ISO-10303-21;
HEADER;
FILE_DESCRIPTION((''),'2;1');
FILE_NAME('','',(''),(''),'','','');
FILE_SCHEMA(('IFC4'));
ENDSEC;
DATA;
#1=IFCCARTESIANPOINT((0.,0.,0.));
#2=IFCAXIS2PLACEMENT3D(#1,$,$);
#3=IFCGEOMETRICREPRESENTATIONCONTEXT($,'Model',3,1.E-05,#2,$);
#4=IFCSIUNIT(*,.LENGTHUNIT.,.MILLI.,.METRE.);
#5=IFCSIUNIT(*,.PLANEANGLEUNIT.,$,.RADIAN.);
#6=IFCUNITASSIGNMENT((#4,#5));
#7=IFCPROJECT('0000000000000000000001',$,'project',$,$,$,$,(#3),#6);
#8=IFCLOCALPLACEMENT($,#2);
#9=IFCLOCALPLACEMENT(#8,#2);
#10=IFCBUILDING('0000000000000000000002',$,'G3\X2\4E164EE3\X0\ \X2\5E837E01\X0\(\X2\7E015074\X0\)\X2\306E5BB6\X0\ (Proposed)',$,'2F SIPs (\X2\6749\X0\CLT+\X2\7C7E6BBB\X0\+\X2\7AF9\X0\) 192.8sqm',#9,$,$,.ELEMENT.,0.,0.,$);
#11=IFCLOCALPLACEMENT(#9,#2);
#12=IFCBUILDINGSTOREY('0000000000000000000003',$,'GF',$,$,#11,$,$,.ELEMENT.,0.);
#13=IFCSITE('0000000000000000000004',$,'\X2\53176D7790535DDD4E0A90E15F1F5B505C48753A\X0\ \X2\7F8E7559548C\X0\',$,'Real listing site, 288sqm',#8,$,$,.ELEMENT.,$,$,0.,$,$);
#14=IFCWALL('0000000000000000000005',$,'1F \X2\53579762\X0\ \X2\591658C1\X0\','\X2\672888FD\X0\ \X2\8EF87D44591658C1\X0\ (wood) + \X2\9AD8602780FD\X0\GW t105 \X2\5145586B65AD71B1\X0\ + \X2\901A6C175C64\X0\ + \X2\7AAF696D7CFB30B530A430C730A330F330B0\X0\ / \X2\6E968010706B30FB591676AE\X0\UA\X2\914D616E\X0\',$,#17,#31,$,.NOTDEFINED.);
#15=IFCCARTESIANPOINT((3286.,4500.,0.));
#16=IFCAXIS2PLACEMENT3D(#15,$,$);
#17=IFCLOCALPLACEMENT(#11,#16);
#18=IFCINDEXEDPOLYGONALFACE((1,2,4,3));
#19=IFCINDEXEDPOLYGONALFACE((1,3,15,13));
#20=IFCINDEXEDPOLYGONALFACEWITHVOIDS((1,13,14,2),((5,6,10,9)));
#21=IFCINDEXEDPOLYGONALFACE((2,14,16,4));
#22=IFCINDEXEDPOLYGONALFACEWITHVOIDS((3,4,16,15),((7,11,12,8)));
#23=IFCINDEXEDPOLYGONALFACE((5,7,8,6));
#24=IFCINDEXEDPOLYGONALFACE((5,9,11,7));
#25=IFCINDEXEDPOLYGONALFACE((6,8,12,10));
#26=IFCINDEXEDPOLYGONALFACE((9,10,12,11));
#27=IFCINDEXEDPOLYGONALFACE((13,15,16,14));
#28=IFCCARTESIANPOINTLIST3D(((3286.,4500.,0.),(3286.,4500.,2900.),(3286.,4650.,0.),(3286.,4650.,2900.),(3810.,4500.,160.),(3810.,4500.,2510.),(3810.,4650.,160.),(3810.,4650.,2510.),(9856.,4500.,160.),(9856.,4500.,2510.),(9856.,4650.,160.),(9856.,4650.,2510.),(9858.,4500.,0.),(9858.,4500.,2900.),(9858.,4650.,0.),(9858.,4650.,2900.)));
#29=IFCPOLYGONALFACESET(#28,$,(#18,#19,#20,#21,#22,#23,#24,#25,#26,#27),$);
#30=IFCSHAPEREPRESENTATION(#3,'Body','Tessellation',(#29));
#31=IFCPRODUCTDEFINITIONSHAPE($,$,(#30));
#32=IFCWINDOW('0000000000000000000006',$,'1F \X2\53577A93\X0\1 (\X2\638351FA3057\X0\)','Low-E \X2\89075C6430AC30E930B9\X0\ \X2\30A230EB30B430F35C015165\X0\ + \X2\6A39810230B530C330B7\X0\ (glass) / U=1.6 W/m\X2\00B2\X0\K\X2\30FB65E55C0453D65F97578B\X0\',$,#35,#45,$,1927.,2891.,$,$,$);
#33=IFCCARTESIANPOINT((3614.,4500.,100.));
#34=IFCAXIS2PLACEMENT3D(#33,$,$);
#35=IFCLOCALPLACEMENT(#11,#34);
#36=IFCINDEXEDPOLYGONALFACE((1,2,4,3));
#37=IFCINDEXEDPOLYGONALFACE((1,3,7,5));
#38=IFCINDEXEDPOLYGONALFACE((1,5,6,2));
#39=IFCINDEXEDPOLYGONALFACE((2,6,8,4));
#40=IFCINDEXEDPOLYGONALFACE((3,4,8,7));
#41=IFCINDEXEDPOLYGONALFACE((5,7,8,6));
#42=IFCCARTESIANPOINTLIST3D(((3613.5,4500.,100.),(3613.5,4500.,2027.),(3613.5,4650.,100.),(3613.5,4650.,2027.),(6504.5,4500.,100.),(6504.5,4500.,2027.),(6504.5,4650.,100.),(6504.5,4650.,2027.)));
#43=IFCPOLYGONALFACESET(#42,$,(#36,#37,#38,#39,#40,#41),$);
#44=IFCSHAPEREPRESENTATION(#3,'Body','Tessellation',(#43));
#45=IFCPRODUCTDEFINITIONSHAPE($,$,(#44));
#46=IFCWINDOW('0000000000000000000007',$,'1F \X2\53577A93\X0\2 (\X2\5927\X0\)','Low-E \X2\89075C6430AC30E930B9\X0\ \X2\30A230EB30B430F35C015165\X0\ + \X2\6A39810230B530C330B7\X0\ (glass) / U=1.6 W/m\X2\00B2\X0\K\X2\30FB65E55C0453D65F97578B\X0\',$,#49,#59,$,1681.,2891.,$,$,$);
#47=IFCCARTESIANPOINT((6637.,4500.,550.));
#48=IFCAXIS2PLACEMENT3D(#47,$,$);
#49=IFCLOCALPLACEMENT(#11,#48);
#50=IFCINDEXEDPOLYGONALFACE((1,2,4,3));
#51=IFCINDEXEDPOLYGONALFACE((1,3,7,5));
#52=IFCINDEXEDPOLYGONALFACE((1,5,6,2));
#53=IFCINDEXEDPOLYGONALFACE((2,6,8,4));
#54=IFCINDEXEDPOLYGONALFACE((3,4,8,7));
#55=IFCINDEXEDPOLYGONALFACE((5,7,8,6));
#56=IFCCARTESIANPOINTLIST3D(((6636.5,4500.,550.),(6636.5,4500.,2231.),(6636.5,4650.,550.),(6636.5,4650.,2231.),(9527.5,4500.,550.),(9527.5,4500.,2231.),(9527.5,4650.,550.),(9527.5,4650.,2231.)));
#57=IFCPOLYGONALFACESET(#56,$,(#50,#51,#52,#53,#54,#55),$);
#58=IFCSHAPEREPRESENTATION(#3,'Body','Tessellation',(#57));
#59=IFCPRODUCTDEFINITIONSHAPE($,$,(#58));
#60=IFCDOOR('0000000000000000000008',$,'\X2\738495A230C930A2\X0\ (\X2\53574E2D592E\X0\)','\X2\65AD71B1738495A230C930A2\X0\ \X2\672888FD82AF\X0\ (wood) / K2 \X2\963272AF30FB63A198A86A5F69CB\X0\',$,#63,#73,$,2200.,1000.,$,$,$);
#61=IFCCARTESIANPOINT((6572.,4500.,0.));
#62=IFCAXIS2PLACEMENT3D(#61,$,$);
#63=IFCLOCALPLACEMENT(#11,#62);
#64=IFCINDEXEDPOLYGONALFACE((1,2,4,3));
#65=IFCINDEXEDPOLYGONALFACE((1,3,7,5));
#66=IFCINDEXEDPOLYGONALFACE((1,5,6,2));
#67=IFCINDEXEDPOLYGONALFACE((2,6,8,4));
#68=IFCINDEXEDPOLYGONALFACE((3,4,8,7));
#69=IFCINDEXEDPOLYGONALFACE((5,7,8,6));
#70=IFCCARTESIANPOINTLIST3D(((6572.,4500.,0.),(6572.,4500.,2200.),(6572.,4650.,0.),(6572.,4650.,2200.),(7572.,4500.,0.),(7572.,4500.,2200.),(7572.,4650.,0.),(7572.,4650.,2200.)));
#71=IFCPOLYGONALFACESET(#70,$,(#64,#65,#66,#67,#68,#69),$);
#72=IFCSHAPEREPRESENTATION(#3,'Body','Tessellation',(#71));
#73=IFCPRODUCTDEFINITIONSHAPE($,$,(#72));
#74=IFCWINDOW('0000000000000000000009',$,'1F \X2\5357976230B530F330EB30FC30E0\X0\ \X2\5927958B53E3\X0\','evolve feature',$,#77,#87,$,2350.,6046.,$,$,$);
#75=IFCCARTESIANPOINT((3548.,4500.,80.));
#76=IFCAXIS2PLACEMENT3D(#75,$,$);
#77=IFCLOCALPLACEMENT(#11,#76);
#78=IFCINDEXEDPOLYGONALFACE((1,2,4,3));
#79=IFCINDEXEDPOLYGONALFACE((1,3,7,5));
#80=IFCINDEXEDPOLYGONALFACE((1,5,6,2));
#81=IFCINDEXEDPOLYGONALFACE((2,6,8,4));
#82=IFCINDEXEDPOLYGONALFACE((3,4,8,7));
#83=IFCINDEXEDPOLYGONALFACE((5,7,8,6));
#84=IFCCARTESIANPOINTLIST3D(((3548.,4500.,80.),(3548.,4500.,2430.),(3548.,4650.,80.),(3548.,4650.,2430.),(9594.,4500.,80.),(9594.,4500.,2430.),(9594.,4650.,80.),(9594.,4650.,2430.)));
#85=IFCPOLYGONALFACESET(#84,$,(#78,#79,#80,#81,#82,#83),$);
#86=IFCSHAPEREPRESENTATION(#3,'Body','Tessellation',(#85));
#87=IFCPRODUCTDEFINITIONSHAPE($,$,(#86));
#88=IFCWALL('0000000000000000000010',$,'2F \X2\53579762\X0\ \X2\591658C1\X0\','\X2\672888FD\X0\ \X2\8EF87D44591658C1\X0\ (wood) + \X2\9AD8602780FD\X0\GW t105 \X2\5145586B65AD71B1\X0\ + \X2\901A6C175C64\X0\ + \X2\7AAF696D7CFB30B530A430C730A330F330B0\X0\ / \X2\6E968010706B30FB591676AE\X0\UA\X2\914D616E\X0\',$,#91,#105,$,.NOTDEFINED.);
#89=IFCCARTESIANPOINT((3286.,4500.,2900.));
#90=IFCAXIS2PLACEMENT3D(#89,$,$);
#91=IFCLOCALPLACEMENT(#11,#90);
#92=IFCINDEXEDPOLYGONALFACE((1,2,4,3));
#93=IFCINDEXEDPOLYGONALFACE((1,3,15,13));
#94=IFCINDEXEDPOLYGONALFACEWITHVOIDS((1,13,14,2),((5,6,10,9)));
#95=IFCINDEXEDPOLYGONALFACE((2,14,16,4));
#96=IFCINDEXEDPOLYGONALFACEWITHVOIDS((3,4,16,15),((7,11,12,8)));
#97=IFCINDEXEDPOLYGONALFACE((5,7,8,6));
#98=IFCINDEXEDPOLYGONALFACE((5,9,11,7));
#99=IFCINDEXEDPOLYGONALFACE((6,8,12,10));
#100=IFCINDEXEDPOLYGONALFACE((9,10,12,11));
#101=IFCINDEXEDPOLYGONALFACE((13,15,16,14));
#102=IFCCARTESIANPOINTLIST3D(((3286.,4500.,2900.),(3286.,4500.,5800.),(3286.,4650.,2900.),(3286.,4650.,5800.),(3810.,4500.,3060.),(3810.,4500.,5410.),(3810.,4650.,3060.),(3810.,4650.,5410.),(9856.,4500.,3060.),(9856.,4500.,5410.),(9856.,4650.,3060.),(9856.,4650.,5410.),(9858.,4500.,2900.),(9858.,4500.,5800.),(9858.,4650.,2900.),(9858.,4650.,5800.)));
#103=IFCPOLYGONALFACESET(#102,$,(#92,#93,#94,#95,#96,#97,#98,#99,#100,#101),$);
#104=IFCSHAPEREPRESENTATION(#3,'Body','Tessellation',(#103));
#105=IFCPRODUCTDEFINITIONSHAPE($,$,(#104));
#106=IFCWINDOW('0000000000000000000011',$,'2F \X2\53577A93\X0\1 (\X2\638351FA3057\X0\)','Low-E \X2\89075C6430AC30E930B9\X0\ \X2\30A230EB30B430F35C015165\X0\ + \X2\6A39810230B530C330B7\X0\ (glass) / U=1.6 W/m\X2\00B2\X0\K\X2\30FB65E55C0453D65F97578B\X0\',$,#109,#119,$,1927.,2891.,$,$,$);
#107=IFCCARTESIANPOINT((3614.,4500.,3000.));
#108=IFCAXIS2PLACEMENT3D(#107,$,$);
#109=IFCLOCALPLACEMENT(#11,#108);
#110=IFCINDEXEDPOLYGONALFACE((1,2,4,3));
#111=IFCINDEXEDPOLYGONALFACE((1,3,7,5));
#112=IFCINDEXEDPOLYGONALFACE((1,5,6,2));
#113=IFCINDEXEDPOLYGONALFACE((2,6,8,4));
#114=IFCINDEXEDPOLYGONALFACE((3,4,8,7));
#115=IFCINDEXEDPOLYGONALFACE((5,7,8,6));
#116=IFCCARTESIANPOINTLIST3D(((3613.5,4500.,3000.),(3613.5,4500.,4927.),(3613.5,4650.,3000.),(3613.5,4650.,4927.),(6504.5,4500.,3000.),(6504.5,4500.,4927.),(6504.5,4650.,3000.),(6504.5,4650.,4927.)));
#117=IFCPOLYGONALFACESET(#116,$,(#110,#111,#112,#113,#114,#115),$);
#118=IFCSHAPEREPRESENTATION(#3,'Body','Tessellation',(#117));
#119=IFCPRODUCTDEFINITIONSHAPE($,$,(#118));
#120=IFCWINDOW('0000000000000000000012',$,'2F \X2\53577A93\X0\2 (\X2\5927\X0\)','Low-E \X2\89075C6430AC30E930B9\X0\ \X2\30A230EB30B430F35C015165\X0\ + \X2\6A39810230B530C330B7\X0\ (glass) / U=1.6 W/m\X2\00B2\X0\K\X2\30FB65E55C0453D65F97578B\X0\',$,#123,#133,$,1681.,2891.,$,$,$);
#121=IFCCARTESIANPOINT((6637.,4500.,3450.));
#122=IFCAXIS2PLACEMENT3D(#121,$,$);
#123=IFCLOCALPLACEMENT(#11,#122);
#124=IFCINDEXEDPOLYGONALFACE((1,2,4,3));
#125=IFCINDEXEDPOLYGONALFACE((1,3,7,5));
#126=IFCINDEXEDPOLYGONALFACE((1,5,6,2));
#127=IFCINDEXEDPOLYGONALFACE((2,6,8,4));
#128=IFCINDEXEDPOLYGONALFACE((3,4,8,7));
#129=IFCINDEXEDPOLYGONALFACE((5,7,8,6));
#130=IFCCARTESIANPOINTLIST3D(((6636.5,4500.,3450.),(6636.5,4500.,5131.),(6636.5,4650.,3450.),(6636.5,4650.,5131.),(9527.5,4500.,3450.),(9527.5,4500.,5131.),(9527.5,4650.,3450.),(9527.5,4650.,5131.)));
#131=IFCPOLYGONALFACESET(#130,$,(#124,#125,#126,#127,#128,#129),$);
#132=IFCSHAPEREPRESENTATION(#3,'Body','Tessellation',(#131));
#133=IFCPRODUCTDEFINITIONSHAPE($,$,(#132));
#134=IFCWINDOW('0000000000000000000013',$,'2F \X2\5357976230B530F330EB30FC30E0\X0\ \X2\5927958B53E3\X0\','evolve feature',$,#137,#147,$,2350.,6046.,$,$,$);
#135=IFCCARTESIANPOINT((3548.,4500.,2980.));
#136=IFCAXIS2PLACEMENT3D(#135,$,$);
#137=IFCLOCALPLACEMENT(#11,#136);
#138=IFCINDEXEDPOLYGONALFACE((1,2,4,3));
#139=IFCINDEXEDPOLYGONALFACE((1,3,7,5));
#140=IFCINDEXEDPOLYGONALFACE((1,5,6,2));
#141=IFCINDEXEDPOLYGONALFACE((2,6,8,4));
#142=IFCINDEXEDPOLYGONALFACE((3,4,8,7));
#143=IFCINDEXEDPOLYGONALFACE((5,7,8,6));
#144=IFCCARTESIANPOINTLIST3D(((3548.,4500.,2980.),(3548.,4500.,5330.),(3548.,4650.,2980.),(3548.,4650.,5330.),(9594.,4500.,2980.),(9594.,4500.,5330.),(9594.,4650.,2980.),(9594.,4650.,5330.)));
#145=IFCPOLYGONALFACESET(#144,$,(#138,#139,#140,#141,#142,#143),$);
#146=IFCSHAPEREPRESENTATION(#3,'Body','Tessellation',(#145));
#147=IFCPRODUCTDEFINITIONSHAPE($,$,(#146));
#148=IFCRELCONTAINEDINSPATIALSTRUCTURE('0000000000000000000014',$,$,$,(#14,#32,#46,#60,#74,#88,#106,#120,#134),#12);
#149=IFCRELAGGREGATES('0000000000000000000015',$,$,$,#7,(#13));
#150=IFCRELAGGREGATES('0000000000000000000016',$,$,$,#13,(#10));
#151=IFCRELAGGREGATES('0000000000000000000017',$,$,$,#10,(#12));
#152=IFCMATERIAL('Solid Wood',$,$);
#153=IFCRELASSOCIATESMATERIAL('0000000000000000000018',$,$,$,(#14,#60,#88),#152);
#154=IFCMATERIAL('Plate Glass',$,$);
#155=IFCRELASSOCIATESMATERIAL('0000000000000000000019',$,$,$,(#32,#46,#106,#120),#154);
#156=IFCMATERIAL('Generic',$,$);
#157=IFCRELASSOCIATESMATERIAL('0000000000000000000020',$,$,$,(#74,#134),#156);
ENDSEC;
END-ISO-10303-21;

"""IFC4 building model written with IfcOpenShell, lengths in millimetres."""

from ifc_helpers import new_model, si_unit, frame, frame_2d, origin, place, context, project, spatial, rectangle, extrude, material, element, fill, save


model = new_model("IFC4")

# Units and contexts
model_context = context("Model", 3, precision=1e-05, world=origin())
ifc_project = project(units=[si_unit("LENGTHUNIT", "METRE", prefix="MILLI"), si_unit("PLANEANGLEUNIT", "RADIAN")], contexts=[model_context])

# Site, building, storey
site_placement = place(None, origin())
site = spatial("IfcSite", under=ifc_project, at=site_placement, Name="北海道川上郡弟子屈町 美留和", ObjectType="Real listing site, 288sqm", CompositionType="ELEMENT", RefElevation=0.0)
building_placement = place(site_placement, origin())
building = spatial("IfcBuilding", under=site, at=building_placement, Name="G3世代 広縁(縁側)の家 (Proposed)", ObjectType="2F SIPs (杉CLT+籾殻+竹) 192.8sqm", CompositionType="ELEMENT", ElevationOfRefHeight=0.0, ElevationOfTerrain=0.0)
storey_placement = place(building_placement, origin())
storey = spatial("IfcBuildingStorey", under=building, at=storey_placement, Name="GF", CompositionType="ELEMENT", Elevation=0.0)

# Shared definitions
ifc_material_1 = material(Name="Solid Wood")

# Wall, openings, windows, door
wall_1_placement = place(storey_placement, frame((3286.0, 4500.0, 0.0)))
wall_1 = element("IfcWall", 1, at=wall_1_placement, inside=storey, material=ifc_material_1, Name="1F 南面 外壁", Description="木製 軸組外壁 (wood) + 高性能GW t105 充填断熱 + 通気層 + 窯業系サイディング / 準耐火・外皮UA配慮", PredefinedType="NOTDEFINED", context=model_context, shape_type="SweptSolid", body=[
    extrude(rectangle(XDim=6572.0, YDim=150.0, at=frame_2d((3286.0, 75.0))), frame((3286.0, 4500.0, 0.0)), (0.0, 0.0, 1.0), 2900.0),
])
opening_1_placement = place(storey_placement, frame((3614.0, 4500.0, 100.0)))
opening_1 = element("IfcOpeningElement", 2, at=opening_1_placement, cuts=wall_1, PredefinedType="NOTDEFINED", context=model_context, shape_type="SweptSolid", body=[
    extrude(rectangle(XDim=2891.0, YDim=150.0, at=frame_2d((1445.0, 75.0))), frame((3614.0, 4500.0, 100.0)), (0.0, 0.0, 1.0), 1927.0),
])
opening_2_placement = place(storey_placement, frame((6637.0, 4500.0, 550.0)))
opening_2 = element("IfcOpeningElement", 3, at=opening_2_placement, cuts=wall_1, PredefinedType="NOTDEFINED", context=model_context, shape_type="SweptSolid", body=[
    extrude(rectangle(XDim=2891.0, YDim=150.0, at=frame_2d((1445.0, 75.0))), frame((6637.0, 4500.0, 550.0)), (0.0, 0.0, 1.0), 1681.0),
])
opening_3_placement = place(storey_placement, frame((6572.0, 4500.0, 0.0)))
opening_3 = element("IfcOpeningElement", 4, at=opening_3_placement, cuts=wall_1, PredefinedType="NOTDEFINED", context=model_context, shape_type="SweptSolid", body=[
    extrude(rectangle(XDim=1000.0, YDim=150.0, at=frame_2d((500.0, 75.0))), frame((6572.0, 4500.0, 0.0)), (0.0, 0.0, 1.0), 2200.0),
])
opening_4_placement = place(storey_placement, frame((3548.0, 4500.0, 80.0)))
opening_4 = element("IfcOpeningElement", 5, at=opening_4_placement, cuts=wall_1, PredefinedType="NOTDEFINED", context=model_context, shape_type="SweptSolid", body=[
    extrude(rectangle(XDim=6046.0, YDim=150.0, at=frame_2d((3023.0, 75.0))), frame((3548.0, 4500.0, 80.0)), (0.0, 0.0, 1.0), 2350.0),
])
ifc_material_2 = material(Name="Plate Glass")
window_1_placement = place(storey_placement, frame((3614.0, 4500.0, 100.0)))
window_1 = element("IfcWindow", 6, at=window_1_placement, inside=storey, material=ifc_material_2, Name="1F 南窓1 (掃出し)", Description="Low-E 複層ガラス アルゴン封入 + 樹脂サッシ (glass) / U=1.6 W/m²K・日射取得型", OverallHeight=1927.0, OverallWidth=2891.0, context=model_context, shape_type="SweptSolid", body=[
    extrude(rectangle(XDim=2891.0, YDim=150.0, at=frame_2d((1445.0, 75.0))), frame((3614.0, 4500.0, 100.0)), (0.0, 0.0, 1.0), 1927.0),
])
fill(opening_1, window_1)
window_2_placement = place(storey_placement, frame((6637.0, 4500.0, 550.0)))
window_2 = element("IfcWindow", 7, at=window_2_placement, inside=storey, material=ifc_material_2, Name="1F 南窓2 (大)", Description="Low-E 複層ガラス アルゴン封入 + 樹脂サッシ (glass) / U=1.6 W/m²K・日射取得型", OverallHeight=1681.0, OverallWidth=2891.0, context=model_context, shape_type="SweptSolid", body=[
    extrude(rectangle(XDim=2891.0, YDim=150.0, at=frame_2d((1445.0, 75.0))), frame((6637.0, 4500.0, 550.0)), (0.0, 0.0, 1.0), 1681.0),
])
fill(opening_2, window_2)
door_placement = place(storey_placement, frame((6572.0, 4500.0, 0.0)))
door = element("IfcDoor", 8, at=door_placement, inside=storey, material=ifc_material_1, Name="玄関ドア (南中央)", Description="断熱玄関ドア 木製芯 (wood) / K2 防犯・採風機構", OverallHeight=2200.0, OverallWidth=1000.0, context=model_context, shape_type="SweptSolid", body=[
    extrude(rectangle(XDim=1000.0, YDim=150.0, at=frame_2d((500.0, 75.0))), frame((6572.0, 4500.0, 0.0)), (0.0, 0.0, 1.0), 2200.0),
])
fill(opening_3, door)
ifc_material_3 = material(Name="Generic")
window_3_placement = place(storey_placement, frame((3548.0, 4500.0, 80.0)))
window_3 = element("IfcWindow", 9, at=window_3_placement, inside=storey, material=ifc_material_3, Name="1F 南面サンルーム 大開口", Description="evolve feature", OverallHeight=2350.0, OverallWidth=6046.0, context=model_context, shape_type="SweptSolid", body=[
    extrude(rectangle(XDim=6046.0, YDim=150.0, at=frame_2d((3023.0, 75.0))), frame((3548.0, 4500.0, 80.0)), (0.0, 0.0, 1.0), 2350.0),
])
fill(opening_4, window_3)

# Wall, openings, windows
wall_2_placement = place(storey_placement, frame((3286.0, 4500.0, 2900.0)))
wall_2 = element("IfcWall", 10, at=wall_2_placement, inside=storey, material=ifc_material_1, Name="2F 南面 外壁", Description="木製 軸組外壁 (wood) + 高性能GW t105 充填断熱 + 通気層 + 窯業系サイディング / 準耐火・外皮UA配慮", PredefinedType="NOTDEFINED", context=model_context, shape_type="SweptSolid", body=[
    extrude(rectangle(XDim=6572.0, YDim=150.0, at=frame_2d((3286.0, 75.0))), frame((3286.0, 4500.0, 2900.0)), (0.0, 0.0, 1.0), 2900.0),
])
opening_5_placement = place(storey_placement, frame((3614.0, 4500.0, 3000.0)))
opening_5 = element("IfcOpeningElement", 11, at=opening_5_placement, cuts=wall_2, PredefinedType="NOTDEFINED", context=model_context, shape_type="SweptSolid", body=[
    extrude(rectangle(XDim=2891.0, YDim=150.0, at=frame_2d((1445.0, 75.0))), frame((3614.0, 4500.0, 3000.0)), (0.0, 0.0, 1.0), 1927.0),
])
opening_6_placement = place(storey_placement, frame((6637.0, 4500.0, 3450.0)))
opening_6 = element("IfcOpeningElement", 12, at=opening_6_placement, cuts=wall_2, PredefinedType="NOTDEFINED", context=model_context, shape_type="SweptSolid", body=[
    extrude(rectangle(XDim=2891.0, YDim=150.0, at=frame_2d((1445.0, 75.0))), frame((6637.0, 4500.0, 3450.0)), (0.0, 0.0, 1.0), 1681.0),
])
opening_7_placement = place(storey_placement, frame((3548.0, 4500.0, 2980.0)))
opening_7 = element("IfcOpeningElement", 13, at=opening_7_placement, cuts=wall_2, PredefinedType="NOTDEFINED", context=model_context, shape_type="SweptSolid", body=[
    extrude(rectangle(XDim=6046.0, YDim=150.0, at=frame_2d((3023.0, 75.0))), frame((3548.0, 4500.0, 2980.0)), (0.0, 0.0, 1.0), 2350.0),
])
window_4_placement = place(storey_placement, frame((3614.0, 4500.0, 3000.0)))
window_4 = element("IfcWindow", 14, at=window_4_placement, inside=storey, material=ifc_material_2, Name="2F 南窓1 (掃出し)", Description="Low-E 複層ガラス アルゴン封入 + 樹脂サッシ (glass) / U=1.6 W/m²K・日射取得型", OverallHeight=1927.0, OverallWidth=2891.0, context=model_context, shape_type="SweptSolid", body=[
    extrude(rectangle(XDim=2891.0, YDim=150.0, at=frame_2d((1445.0, 75.0))), frame((3614.0, 4500.0, 3000.0)), (0.0, 0.0, 1.0), 1927.0),
])
fill(opening_5, window_4)
window_5_placement = place(storey_placement, frame((6637.0, 4500.0, 3450.0)))
window_5 = element("IfcWindow", 15, at=window_5_placement, inside=storey, material=ifc_material_2, Name="2F 南窓2 (大)", Description="Low-E 複層ガラス アルゴン封入 + 樹脂サッシ (glass) / U=1.6 W/m²K・日射取得型", OverallHeight=1681.0, OverallWidth=2891.0, context=model_context, shape_type="SweptSolid", body=[
    extrude(rectangle(XDim=2891.0, YDim=150.0, at=frame_2d((1445.0, 75.0))), frame((6637.0, 4500.0, 3450.0)), (0.0, 0.0, 1.0), 1681.0),
])
fill(opening_6, window_5)
window_6_placement = place(storey_placement, frame((3548.0, 4500.0, 2980.0)))
window_6 = element("IfcWindow", 16, at=window_6_placement, inside=storey, material=ifc_material_3, Name="2F 南面サンルーム 大開口", Description="evolve feature", OverallHeight=2350.0, OverallWidth=6046.0, context=model_context, shape_type="SweptSolid", body=[
    extrude(rectangle(XDim=6046.0, YDim=150.0, at=frame_2d((3023.0, 75.0))), frame((3548.0, 4500.0, 2980.0)), (0.0, 0.0, 1.0), 2350.0),
])
fill(opening_7, window_6)

save(model, "model.ifc")
